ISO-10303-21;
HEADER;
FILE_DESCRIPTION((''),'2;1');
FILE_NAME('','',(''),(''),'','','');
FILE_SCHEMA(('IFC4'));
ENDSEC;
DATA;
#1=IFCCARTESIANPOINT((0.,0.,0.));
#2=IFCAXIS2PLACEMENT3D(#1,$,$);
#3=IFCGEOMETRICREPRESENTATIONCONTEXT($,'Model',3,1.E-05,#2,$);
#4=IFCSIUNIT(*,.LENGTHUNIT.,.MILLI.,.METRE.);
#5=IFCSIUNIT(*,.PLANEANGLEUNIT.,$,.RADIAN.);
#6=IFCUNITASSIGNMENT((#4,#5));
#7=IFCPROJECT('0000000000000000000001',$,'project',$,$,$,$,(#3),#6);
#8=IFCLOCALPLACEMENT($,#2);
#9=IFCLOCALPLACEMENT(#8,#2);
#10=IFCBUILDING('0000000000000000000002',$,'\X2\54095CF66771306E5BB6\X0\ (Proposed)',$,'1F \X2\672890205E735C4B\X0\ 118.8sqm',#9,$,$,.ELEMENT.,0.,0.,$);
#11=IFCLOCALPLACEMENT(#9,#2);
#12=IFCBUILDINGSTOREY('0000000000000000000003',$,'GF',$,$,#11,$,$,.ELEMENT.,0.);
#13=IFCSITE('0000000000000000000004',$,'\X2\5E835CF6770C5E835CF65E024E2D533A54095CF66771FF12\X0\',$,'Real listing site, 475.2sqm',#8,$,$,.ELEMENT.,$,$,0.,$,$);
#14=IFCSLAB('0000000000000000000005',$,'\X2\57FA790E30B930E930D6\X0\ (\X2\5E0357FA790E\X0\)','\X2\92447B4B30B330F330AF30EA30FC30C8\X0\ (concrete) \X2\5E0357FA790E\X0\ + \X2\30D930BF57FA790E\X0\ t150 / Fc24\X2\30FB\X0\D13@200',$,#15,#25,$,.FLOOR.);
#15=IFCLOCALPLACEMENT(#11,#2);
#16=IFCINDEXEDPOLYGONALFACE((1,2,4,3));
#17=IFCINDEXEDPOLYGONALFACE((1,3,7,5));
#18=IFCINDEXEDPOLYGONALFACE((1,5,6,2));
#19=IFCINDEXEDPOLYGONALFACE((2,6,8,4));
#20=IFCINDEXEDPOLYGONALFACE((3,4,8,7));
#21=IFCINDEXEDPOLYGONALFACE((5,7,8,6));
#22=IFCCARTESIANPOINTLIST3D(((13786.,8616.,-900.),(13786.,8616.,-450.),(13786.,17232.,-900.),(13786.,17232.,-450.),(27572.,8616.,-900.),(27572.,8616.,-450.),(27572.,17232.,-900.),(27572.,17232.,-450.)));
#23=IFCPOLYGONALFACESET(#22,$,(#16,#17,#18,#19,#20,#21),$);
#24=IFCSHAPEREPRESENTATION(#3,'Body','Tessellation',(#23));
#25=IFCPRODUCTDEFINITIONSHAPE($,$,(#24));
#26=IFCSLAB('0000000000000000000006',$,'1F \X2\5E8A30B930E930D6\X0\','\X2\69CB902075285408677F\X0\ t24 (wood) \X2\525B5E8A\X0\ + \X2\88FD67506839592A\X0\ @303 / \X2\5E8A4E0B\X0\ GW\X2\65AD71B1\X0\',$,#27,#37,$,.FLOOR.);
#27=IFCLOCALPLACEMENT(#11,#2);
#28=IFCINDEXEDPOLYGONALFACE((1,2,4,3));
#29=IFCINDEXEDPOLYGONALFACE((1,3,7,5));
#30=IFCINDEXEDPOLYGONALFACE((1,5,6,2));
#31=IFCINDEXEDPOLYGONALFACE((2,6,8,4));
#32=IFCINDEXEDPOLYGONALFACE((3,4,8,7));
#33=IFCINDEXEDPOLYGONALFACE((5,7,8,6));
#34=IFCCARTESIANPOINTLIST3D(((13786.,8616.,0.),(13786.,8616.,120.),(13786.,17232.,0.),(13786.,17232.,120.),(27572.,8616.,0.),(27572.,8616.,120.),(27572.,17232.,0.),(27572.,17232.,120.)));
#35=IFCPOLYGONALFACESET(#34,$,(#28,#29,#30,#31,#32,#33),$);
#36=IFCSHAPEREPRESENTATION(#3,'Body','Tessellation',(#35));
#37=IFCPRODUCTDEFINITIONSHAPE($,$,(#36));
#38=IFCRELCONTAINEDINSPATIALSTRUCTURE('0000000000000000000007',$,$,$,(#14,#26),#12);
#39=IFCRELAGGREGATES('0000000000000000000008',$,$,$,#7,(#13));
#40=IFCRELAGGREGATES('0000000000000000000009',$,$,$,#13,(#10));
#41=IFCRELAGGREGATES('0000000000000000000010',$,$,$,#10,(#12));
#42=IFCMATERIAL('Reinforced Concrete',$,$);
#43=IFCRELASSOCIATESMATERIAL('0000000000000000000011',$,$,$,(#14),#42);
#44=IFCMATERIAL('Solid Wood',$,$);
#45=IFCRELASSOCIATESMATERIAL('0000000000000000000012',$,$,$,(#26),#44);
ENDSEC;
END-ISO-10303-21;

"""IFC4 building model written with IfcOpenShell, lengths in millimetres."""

from ifc_helpers import new_model, si_unit, frame, frame_2d, origin, place, context, project, spatial, rectangle, extrude, material, element, save


model = new_model("IFC4")

# Units and contexts
model_context = context("Model", 3, precision=1e-05, world=origin())
ifc_project = project(units=[si_unit("LENGTHUNIT", "METRE", prefix="MILLI"), si_unit("PLANEANGLEUNIT", "RADIAN")], contexts=[model_context])

# Site, building, storey
site_placement = place(None, origin())
site = spatial("IfcSite", under=ifc_project, at=site_placement, Name="広島県広島市中区吉島東２", ObjectType="Real listing site, 475.2sqm", CompositionType="ELEMENT", RefElevation=0.0)
building_placement = place(site_placement, origin())
building = spatial("IfcBuilding", under=site, at=building_placement, Name="吉島東の家 (Proposed)", ObjectType="1F 木造平屋 118.8sqm", CompositionType="ELEMENT", ElevationOfRefHeight=0.0, ElevationOfTerrain=0.0)
storey_placement = place(building_placement, origin())
storey = spatial("IfcBuildingStorey", under=building, at=storey_placement, Name="GF", CompositionType="ELEMENT", Elevation=0.0)

# Slabs
ifc_material_1 = material(Name="Reinforced Concrete")
slab_1_placement = place(storey_placement, frame((6893.0, 4308.0, -450.0)))
element("IfcSlab", 1, at=slab_1_placement, inside=storey, material=ifc_material_1, Name="基礎スラブ (布基礎)", Description="鉄筋コンクリート (concrete) 布基礎 + ベタ基礎 t150 / Fc24・D13@200", PredefinedType="FLOOR", context=model_context, shape_type="SweptSolid", body=[
    extrude(rectangle(XDim=13786.0, YDim=8616.0, at=frame_2d((6893.0, 4308.0))), frame((6893.0, 4308.0, -450.0)), (0.0, 0.0, 1.0), 450.0),
])
ifc_material_2 = material(Name="Solid Wood")
slab_2_placement = place(storey_placement, frame((6893.0, 4308.0, 0.0)))
element("IfcSlab", 2, at=slab_2_placement, inside=storey, material=ifc_material_2, Name="1F 床スラブ", Description="構造用合板 t24 (wood) 剛床 + 製材根太 @303 / 床下 GW断熱", PredefinedType="FLOOR", context=model_context, shape_type="SweptSolid", body=[
    extrude(rectangle(XDim=13786.0, YDim=8616.0, at=frame_2d((6893.0, 4308.0))), frame((6893.0, 4308.0, 0.0)), (0.0, 0.0, 1.0), 120.0),
])

save(model, "model.ifc")
